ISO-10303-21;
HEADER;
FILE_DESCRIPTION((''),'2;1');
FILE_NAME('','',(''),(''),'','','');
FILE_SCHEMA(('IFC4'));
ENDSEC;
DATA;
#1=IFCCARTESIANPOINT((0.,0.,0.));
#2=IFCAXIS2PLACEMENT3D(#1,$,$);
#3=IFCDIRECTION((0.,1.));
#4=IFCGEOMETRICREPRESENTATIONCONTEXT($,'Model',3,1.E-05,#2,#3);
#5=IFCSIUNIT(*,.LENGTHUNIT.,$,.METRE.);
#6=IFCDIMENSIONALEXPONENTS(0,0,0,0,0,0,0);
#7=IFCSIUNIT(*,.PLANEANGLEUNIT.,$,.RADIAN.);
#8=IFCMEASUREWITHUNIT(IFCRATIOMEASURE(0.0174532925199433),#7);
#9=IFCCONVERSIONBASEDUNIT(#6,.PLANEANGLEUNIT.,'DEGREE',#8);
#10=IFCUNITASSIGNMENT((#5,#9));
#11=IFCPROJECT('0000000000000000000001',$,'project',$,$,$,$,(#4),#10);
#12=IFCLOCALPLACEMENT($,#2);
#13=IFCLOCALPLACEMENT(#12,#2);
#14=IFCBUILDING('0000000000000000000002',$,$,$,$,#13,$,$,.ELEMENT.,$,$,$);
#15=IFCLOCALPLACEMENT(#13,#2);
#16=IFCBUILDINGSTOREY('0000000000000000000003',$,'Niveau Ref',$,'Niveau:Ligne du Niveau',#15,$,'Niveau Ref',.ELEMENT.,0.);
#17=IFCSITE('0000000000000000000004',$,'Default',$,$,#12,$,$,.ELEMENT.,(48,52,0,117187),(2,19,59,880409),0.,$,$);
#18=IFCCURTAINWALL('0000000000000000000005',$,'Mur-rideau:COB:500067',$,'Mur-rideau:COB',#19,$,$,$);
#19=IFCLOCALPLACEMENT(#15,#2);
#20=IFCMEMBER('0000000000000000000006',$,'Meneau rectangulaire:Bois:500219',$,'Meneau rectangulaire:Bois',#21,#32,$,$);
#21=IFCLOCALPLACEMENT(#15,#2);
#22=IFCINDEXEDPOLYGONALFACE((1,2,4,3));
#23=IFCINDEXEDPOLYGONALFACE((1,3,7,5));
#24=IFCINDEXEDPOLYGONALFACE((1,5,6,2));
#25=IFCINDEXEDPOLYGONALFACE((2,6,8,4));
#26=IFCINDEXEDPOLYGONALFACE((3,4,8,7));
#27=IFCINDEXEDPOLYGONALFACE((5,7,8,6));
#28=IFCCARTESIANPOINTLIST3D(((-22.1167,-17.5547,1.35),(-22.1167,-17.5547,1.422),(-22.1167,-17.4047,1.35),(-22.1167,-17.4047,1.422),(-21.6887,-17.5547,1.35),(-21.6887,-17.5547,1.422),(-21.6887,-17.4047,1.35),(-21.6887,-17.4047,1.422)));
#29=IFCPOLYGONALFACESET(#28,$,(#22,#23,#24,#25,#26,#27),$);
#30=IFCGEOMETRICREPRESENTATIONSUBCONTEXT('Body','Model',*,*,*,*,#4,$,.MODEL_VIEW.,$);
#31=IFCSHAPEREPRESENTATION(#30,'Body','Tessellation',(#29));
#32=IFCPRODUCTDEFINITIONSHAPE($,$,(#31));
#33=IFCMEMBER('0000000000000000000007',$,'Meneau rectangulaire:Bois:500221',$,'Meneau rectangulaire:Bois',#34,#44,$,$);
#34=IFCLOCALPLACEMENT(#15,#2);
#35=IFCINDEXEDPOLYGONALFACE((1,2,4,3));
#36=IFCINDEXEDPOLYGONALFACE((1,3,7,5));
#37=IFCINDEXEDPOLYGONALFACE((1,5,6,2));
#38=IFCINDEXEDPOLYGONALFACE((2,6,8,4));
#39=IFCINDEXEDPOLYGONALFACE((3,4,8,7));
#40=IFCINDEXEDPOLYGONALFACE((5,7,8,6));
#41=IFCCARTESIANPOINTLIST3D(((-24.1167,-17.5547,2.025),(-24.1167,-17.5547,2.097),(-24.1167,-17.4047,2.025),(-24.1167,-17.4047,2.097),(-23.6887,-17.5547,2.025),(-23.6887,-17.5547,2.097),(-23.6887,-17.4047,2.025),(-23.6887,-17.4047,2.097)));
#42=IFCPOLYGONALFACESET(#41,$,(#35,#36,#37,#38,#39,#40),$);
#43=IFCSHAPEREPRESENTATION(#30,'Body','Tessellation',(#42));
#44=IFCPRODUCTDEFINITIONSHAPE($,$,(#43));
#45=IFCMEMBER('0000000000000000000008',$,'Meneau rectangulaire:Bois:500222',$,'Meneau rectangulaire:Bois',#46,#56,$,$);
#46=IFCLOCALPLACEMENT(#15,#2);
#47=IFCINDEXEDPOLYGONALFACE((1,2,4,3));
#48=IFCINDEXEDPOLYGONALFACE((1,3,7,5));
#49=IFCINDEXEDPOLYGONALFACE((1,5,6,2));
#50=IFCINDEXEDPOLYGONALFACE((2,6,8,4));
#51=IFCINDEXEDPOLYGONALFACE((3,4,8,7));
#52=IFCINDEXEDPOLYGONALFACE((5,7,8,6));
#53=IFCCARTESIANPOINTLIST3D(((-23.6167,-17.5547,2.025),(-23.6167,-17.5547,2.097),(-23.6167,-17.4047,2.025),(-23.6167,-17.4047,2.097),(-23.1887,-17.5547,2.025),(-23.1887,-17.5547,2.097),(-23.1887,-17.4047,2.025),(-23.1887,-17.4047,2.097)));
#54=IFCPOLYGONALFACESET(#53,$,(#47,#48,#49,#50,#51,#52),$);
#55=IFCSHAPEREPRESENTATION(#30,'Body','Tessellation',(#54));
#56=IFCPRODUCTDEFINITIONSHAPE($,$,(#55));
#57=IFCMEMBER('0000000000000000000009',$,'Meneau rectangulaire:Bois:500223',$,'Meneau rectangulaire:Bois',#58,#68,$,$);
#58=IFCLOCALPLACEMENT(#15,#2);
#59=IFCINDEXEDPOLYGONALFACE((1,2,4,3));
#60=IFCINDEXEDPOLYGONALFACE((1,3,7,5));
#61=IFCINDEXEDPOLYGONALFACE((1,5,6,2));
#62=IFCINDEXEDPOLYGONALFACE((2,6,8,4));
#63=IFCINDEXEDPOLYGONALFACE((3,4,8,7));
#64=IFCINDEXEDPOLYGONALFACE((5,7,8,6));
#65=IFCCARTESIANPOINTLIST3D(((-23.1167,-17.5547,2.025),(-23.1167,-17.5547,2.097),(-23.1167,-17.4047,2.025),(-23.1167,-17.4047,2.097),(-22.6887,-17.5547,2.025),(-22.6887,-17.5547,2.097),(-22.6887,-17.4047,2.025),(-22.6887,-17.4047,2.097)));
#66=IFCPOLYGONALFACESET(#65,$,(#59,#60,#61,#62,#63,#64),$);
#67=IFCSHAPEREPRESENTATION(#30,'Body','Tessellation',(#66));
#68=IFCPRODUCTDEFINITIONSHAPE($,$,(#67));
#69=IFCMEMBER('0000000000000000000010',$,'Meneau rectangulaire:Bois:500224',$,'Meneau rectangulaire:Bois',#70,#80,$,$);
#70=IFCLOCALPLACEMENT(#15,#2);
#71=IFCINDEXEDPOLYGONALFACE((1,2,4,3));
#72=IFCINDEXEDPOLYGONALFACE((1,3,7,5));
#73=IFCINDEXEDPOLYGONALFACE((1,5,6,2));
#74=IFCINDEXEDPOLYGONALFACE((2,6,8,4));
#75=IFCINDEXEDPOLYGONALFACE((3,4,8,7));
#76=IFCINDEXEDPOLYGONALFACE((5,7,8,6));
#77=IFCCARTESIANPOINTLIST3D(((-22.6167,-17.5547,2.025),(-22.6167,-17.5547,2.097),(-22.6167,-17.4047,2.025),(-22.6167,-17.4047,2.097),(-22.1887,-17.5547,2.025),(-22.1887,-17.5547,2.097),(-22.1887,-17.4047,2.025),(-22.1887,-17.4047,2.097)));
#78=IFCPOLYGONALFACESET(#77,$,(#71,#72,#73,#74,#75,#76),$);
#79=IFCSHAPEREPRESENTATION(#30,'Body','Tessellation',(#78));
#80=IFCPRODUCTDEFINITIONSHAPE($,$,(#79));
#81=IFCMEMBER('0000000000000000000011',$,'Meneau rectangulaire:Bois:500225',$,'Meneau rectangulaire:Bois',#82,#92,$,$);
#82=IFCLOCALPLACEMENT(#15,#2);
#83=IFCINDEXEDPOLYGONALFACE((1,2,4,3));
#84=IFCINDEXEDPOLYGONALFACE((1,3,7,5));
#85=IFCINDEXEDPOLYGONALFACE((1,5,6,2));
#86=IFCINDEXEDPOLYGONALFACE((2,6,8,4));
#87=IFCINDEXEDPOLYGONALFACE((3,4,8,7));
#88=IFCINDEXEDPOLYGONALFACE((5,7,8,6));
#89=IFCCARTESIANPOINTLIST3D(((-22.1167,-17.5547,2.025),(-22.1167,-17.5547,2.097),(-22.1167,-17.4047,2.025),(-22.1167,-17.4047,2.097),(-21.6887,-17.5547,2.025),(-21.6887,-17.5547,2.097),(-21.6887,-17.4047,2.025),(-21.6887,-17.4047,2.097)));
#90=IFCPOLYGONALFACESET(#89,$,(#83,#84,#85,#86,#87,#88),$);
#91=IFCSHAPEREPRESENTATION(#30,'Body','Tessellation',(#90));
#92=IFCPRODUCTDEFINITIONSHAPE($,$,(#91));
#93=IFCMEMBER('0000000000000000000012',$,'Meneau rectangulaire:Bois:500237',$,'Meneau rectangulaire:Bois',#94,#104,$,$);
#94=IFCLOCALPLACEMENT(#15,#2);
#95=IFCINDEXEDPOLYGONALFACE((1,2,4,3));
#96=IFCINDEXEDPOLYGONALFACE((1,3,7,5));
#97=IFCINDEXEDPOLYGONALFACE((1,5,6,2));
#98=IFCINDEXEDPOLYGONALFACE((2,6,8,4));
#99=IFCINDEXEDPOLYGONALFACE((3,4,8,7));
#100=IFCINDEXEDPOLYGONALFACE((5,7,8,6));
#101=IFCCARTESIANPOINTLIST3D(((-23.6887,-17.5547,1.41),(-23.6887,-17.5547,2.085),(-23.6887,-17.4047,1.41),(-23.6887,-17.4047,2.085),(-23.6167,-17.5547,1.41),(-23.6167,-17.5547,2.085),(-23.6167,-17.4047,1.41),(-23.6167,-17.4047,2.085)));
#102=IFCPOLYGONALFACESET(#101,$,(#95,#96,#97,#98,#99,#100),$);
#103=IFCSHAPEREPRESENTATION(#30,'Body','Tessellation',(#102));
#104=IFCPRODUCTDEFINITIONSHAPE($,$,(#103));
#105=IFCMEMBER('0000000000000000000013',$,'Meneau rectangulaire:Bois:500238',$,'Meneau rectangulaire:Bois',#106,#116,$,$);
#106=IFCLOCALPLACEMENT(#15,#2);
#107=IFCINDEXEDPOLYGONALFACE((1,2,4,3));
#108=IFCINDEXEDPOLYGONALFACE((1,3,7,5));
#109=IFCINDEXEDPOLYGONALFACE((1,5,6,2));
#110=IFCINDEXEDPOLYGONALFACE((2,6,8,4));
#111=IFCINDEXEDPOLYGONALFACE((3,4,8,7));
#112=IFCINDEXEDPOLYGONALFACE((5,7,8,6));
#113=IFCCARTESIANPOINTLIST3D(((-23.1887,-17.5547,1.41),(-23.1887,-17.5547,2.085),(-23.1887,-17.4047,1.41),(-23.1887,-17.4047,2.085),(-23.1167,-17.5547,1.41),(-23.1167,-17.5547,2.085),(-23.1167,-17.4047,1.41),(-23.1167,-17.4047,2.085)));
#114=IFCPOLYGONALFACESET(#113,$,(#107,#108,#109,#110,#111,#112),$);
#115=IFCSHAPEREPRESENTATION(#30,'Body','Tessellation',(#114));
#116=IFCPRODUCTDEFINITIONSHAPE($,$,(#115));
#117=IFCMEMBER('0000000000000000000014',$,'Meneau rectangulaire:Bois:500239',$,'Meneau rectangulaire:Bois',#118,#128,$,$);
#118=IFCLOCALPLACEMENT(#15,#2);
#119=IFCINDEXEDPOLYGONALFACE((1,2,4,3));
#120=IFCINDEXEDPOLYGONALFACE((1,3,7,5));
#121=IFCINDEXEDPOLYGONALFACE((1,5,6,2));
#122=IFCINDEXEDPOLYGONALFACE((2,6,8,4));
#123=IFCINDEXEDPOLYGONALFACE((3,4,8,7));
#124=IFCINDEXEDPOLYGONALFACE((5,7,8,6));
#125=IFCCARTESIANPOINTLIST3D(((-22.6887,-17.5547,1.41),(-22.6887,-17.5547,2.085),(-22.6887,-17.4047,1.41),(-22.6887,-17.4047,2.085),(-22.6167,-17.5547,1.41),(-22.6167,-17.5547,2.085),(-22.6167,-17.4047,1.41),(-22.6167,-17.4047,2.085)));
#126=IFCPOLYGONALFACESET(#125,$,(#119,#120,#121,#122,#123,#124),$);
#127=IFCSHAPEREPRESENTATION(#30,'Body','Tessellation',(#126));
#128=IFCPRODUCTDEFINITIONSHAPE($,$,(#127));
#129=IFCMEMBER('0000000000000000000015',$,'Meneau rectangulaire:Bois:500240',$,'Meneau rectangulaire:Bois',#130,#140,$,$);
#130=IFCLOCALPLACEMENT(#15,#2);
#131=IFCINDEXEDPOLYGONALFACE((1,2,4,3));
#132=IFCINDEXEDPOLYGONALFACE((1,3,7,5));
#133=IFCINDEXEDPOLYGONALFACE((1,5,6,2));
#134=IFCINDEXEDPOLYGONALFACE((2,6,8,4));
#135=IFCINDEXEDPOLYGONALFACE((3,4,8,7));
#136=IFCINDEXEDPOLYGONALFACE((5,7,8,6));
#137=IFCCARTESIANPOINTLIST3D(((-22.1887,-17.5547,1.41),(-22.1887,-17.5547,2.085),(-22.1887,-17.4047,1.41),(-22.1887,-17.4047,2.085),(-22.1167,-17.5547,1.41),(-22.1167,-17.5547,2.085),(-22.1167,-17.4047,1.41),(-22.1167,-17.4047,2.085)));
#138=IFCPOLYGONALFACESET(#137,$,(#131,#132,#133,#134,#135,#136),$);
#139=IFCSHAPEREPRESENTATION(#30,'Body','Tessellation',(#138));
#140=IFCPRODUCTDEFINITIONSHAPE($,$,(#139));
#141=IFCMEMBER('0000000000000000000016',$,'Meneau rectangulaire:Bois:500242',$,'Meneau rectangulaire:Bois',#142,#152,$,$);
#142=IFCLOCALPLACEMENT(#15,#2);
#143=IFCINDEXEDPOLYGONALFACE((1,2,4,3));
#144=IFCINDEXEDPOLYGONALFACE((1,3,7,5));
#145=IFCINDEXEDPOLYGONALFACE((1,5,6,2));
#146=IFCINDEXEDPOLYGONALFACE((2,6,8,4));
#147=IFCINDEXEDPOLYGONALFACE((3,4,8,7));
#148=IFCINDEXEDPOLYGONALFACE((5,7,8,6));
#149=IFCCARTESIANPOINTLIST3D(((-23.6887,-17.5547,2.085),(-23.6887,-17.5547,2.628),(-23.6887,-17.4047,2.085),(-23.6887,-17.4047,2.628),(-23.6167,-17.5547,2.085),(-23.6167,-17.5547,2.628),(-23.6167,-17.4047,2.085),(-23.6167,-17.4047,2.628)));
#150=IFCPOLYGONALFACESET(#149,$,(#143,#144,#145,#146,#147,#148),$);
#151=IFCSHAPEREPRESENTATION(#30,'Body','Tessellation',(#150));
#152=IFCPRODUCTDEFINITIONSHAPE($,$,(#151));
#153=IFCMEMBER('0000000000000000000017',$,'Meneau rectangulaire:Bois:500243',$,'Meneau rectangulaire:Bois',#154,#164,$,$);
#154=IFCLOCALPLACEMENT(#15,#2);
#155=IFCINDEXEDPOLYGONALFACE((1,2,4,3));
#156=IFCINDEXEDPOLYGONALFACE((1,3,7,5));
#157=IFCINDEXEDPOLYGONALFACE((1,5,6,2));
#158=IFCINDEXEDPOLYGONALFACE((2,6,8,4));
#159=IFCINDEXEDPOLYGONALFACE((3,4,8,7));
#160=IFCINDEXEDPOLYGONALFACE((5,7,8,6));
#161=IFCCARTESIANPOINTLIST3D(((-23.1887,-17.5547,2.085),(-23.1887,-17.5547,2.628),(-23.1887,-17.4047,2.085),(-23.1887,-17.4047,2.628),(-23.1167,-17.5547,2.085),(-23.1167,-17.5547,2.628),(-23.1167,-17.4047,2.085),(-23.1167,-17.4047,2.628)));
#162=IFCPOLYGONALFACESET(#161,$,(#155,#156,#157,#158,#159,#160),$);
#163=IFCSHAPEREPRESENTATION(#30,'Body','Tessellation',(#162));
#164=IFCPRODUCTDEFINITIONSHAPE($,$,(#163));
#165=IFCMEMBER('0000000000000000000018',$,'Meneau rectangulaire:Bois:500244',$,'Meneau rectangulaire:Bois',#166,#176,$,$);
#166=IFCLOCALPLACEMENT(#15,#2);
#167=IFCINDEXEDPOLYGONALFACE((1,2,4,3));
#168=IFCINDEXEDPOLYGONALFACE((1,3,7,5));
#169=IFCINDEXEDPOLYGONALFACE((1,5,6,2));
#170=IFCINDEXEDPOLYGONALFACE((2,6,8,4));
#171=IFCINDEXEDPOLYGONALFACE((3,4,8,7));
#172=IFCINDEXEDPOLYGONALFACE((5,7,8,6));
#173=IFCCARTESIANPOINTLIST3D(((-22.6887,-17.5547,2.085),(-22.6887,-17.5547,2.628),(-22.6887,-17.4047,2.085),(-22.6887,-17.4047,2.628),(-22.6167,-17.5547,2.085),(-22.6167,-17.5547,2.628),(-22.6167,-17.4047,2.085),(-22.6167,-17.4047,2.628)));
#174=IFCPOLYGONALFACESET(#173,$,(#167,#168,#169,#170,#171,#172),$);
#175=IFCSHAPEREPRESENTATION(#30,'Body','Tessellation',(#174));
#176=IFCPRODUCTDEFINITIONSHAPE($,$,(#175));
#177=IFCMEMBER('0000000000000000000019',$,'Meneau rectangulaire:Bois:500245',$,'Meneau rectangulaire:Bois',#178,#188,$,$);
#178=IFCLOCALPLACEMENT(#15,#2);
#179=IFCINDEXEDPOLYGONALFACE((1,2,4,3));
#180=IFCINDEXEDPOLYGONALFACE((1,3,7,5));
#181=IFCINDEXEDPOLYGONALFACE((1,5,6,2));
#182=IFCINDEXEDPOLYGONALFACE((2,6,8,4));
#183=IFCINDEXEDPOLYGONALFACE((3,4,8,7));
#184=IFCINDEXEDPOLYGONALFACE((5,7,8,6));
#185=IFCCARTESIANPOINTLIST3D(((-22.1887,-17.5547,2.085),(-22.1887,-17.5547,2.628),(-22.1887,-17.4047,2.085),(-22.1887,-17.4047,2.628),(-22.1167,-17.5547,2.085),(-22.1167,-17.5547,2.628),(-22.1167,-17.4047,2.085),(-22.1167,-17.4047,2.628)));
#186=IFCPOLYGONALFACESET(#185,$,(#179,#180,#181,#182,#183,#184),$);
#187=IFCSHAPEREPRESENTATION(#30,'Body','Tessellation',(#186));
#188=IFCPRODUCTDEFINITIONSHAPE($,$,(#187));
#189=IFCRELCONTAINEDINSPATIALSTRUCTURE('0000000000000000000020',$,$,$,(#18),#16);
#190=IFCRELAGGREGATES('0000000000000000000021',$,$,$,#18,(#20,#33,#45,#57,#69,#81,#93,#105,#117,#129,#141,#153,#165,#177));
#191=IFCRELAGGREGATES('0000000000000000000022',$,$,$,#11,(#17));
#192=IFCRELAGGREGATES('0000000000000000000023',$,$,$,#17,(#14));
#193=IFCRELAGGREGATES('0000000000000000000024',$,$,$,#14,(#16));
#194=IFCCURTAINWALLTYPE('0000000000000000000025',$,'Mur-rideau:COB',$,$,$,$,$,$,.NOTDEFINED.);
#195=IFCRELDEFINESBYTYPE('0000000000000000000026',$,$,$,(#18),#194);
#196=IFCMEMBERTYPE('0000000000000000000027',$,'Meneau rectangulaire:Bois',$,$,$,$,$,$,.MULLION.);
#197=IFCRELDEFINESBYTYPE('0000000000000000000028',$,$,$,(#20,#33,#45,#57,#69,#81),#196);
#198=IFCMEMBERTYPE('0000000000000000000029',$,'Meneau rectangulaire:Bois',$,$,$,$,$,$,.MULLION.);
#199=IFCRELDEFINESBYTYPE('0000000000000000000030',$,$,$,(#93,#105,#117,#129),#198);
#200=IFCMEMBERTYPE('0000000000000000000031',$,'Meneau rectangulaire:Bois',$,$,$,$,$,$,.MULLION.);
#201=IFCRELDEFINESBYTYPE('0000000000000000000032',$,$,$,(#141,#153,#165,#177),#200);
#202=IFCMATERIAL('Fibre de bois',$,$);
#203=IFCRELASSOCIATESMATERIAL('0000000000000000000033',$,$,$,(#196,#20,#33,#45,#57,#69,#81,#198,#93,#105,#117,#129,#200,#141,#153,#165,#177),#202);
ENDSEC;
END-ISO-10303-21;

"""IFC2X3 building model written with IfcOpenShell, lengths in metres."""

from ifc_helpers import new_model, entity, si_unit, converted_unit, direction, frame, origin, origin_2d_with_axis, place, context, subcontext, project, spatial, rectangle, extrude, source, transform, mapped, material, type_object, type_shapes, element, aggregate, save


model = new_model("IFC2X3")

# Units and contexts
model_context = context("Model", 3, precision=1e-05, world=origin(), true_north=direction((0.0, 1.0)))
body_context = subcontext(model_context, "Body", "Model", "MODEL_VIEW")
ifc_project = project(units=[si_unit("LENGTHUNIT", "METRE"), converted_unit("PLANEANGLEUNIT", "DEGREE", entity("IfcRatioMeasure", 0.0174532925199433), si_unit("PLANEANGLEUNIT", "RADIAN"), dimensions=[0, 0, 0, 0, 0, 0, 0])], contexts=[model_context])

# Site, building, storey
site_placement = place(None, origin())
site = spatial("IfcSite", under=ifc_project, at=site_placement, Name="Default", CompositionType="ELEMENT", RefLatitude=(48, 52, 0, 117187), RefLongitude=(2, 19, 59, 880409), RefElevation=0.0)
building_placement = place(site_placement, origin())
building = spatial("IfcBuilding", under=site, at=building_placement, CompositionType="ELEMENT")
storey_placement = place(building_placement, origin())
storey = spatial("IfcBuildingStorey", under=building, at=storey_placement, Name="Niveau Ref", ObjectType="Niveau:Ligne du Niveau", LongName="Niveau Ref", CompositionType="ELEMENT", Elevation=0.0)

# Curtain wall, members
curtain_wall_type = type_object("IfcCurtainWallType", Name="Mur-rideau:COB", PredefinedType="NOTDEFINED")
curtain_wall_placement = place(storey_placement, origin())
curtain_wall = element("IfcCurtainWall", 1, at=curtain_wall_placement, inside=storey, type_object=curtain_wall_type, Name="Mur-rideau:COB:500067", ObjectType="Mur-rideau:COB")
ifc_material = material(Name="Fibre de bois")
member_type_1 = type_object("IfcMemberType", Name="Meneau rectangulaire:Bois", PredefinedType="MULLION", material=ifc_material)
shared_shape_1 = source(origin(), body_context, "Body", "SweptSolid", [
    extrude(rectangle(XDim=0.15, YDim=0.072, at=origin_2d_with_axis()), frame((-0.024, 0.0, -0.428), z_axis=(0.0, 0.0, 1.0), x_axis=(0.0, -1.0, 0.0)), (0.0, 0.0, 1.0), 0.428),
])
type_shapes(member_type_1, [shared_shape_1])
member_1_placement = place(storey_placement, frame((-21.6887, -17.4797, 1.41), z_axis=(1.0, 0.0, 0.0), x_axis=(0.0, 0.0, 1.0)))
member_1 = element("IfcMember", 2, at=member_1_placement, type_object=member_type_1, material=ifc_material, Name="Meneau rectangulaire:Bois:500219", ObjectType="Meneau rectangulaire:Bois", context=body_context, shape_type="MappedRepresentation", body=[
    mapped(shared_shape_1, transform((0.0, 0.0, 0.0), scale=1.0)),
])
member_2_placement = place(storey_placement, frame((-23.6887, -17.4797, 2.085), z_axis=(1.0, 0.0, 0.0), x_axis=(0.0, 0.0, 1.0)))
member_2 = element("IfcMember", 3, at=member_2_placement, type_object=member_type_1, material=ifc_material, Name="Meneau rectangulaire:Bois:500221", ObjectType="Meneau rectangulaire:Bois", context=body_context, shape_type="MappedRepresentation", body=[
    mapped(shared_shape_1, transform((0.0, 0.0, 0.0), scale=1.0)),
])
member_3_placement = place(storey_placement, frame((-23.1887, -17.4797, 2.085), z_axis=(1.0, 0.0, 0.0), x_axis=(0.0, 0.0, 1.0)))
member_3 = element("IfcMember", 4, at=member_3_placement, type_object=member_type_1, material=ifc_material, Name="Meneau rectangulaire:Bois:500222", ObjectType="Meneau rectangulaire:Bois", context=body_context, shape_type="MappedRepresentation", body=[
    mapped(shared_shape_1, transform((0.0, 0.0, 0.0), scale=1.0)),
])
member_4_placement = place(storey_placement, frame((-22.6887, -17.4797, 2.085), z_axis=(1.0, 0.0, 0.0), x_axis=(0.0, 0.0, 1.0)))
member_4 = element("IfcMember", 5, at=member_4_placement, type_object=member_type_1, material=ifc_material, Name="Meneau rectangulaire:Bois:500223", ObjectType="Meneau rectangulaire:Bois", context=body_context, shape_type="MappedRepresentation", body=[
    mapped(shared_shape_1, transform((0.0, 0.0, 0.0), scale=1.0)),
])
member_5_placement = place(storey_placement, frame((-22.1887, -17.4797, 2.085), z_axis=(1.0, 0.0, 0.0), x_axis=(0.0, 0.0, 1.0)))
member_5 = element("IfcMember", 6, at=member_5_placement, type_object=member_type_1, material=ifc_material, Name="Meneau rectangulaire:Bois:500224", ObjectType="Meneau rectangulaire:Bois", context=body_context, shape_type="MappedRepresentation", body=[
    mapped(shared_shape_1, transform((0.0, 0.0, 0.0), scale=1.0)),
])
member_6_placement = place(storey_placement, frame((-21.6887, -17.4797, 2.085), z_axis=(1.0, 0.0, 0.0), x_axis=(0.0, 0.0, 1.0)))
member_6 = element("IfcMember", 7, at=member_6_placement, type_object=member_type_1, material=ifc_material, Name="Meneau rectangulaire:Bois:500225", ObjectType="Meneau rectangulaire:Bois", context=body_context, shape_type="MappedRepresentation", body=[
    mapped(shared_shape_1, transform((0.0, 0.0, 0.0), scale=1.0)),
])
member_type_2 = type_object("IfcMemberType", Name="Meneau rectangulaire:Bois", PredefinedType="MULLION", material=ifc_material)
shared_shape_2 = source(origin(), body_context, "Body", "SweptSolid", [
    extrude(rectangle(XDim=0.15, YDim=0.072, at=origin_2d_with_axis()), frame((-0.024, 0.0, -0.675), z_axis=(0.0, 0.0, 1.0), x_axis=(0.0, -1.0, 0.0)), (0.0, 0.0, 1.0), 0.675),
])
type_shapes(member_type_2, [shared_shape_2])
member_7_placement = place(storey_placement, frame((-23.6287, -17.4797, 1.41), z_axis=(0.0, 0.0, -1.0), x_axis=(1.0, 0.0, 0.0)))
member_7 = element("IfcMember", 8, at=member_7_placement, type_object=member_type_2, material=ifc_material, Name="Meneau rectangulaire:Bois:500237", ObjectType="Meneau rectangulaire:Bois", context=body_context, shape_type="MappedRepresentation", body=[
    mapped(shared_shape_2, transform((0.0, 0.0, 0.0), scale=1.0)),
])
member_8_placement = place(storey_placement, frame((-23.1287, -17.4797, 1.41), z_axis=(0.0, 0.0, -1.0), x_axis=(1.0, 0.0, 0.0)))
member_8 = element("IfcMember", 9, at=member_8_placement, type_object=member_type_2, material=ifc_material, Name="Meneau rectangulaire:Bois:500238", ObjectType="Meneau rectangulaire:Bois", context=body_context, shape_type="MappedRepresentation", body=[
    mapped(shared_shape_2, transform((0.0, 0.0, 0.0), scale=1.0)),
])
member_9_placement = place(storey_placement, frame((-22.6287, -17.4797, 1.41), z_axis=(0.0, 0.0, -1.0), x_axis=(1.0, 0.0, 0.0)))
member_9 = element("IfcMember", 10, at=member_9_placement, type_object=member_type_2, material=ifc_material, Name="Meneau rectangulaire:Bois:500239", ObjectType="Meneau rectangulaire:Bois", context=body_context, shape_type="MappedRepresentation", body=[
    mapped(shared_shape_2, transform((0.0, 0.0, 0.0), scale=1.0)),
])
member_10_placement = place(storey_placement, frame((-22.1287, -17.4797, 1.41), z_axis=(0.0, 0.0, -1.0), x_axis=(1.0, 0.0, 0.0)))
member_10 = element("IfcMember", 11, at=member_10_placement, type_object=member_type_2, material=ifc_material, Name="Meneau rectangulaire:Bois:500240", ObjectType="Meneau rectangulaire:Bois", context=body_context, shape_type="MappedRepresentation", body=[
    mapped(shared_shape_2, transform((0.0, 0.0, 0.0), scale=1.0)),
])
member_type_3 = type_object("IfcMemberType", Name="Meneau rectangulaire:Bois", PredefinedType="MULLION", material=ifc_material)
shared_shape_3 = source(origin(), body_context, "Body", "SweptSolid", [
    extrude(rectangle(XDim=0.15, YDim=0.072, at=origin_2d_with_axis()), frame((-0.024, 0.0, -0.543), z_axis=(0.0, 0.0, 1.0), x_axis=(0.0, -1.0, 0.0)), (0.0, 0.0, 1.0), 0.543),
])
type_shapes(member_type_3, [shared_shape_3])
member_11_placement = place(storey_placement, frame((-23.6287, -17.4797, 2.085), z_axis=(0.0, 0.0, -1.0), x_axis=(1.0, 0.0, 0.0)))
member_11 = element("IfcMember", 12, at=member_11_placement, type_object=member_type_3, material=ifc_material, Name="Meneau rectangulaire:Bois:500242", ObjectType="Meneau rectangulaire:Bois", context=body_context, shape_type="MappedRepresentation", body=[
    mapped(shared_shape_3, transform((0.0, 0.0, 0.0), scale=1.0)),
])
member_12_placement = place(storey_placement, frame((-23.1287, -17.4797, 2.085), z_axis=(0.0, 0.0, -1.0), x_axis=(1.0, 0.0, 0.0)))
member_12 = element("IfcMember", 13, at=member_12_placement, type_object=member_type_3, material=ifc_material, Name="Meneau rectangulaire:Bois:500243", ObjectType="Meneau rectangulaire:Bois", context=body_context, shape_type="MappedRepresentation", body=[
    mapped(shared_shape_3, transform((0.0, 0.0, 0.0), scale=1.0)),
])
member_13_placement = place(storey_placement, frame((-22.6287, -17.4797, 2.085), z_axis=(0.0, 0.0, -1.0), x_axis=(1.0, 0.0, 0.0)))
member_13 = element("IfcMember", 14, at=member_13_placement, type_object=member_type_3, material=ifc_material, Name="Meneau rectangulaire:Bois:500244", ObjectType="Meneau rectangulaire:Bois", context=body_context, shape_type="MappedRepresentation", body=[
    mapped(shared_shape_3, transform((0.0, 0.0, 0.0), scale=1.0)),
])
member_14_placement = place(storey_placement, frame((-22.1287, -17.4797, 2.085), z_axis=(0.0, 0.0, -1.0), x_axis=(1.0, 0.0, 0.0)))
member_14 = element("IfcMember", 15, at=member_14_placement, type_object=member_type_3, material=ifc_material, Name="Meneau rectangulaire:Bois:500245", ObjectType="Meneau rectangulaire:Bois", context=body_context, shape_type="MappedRepresentation", body=[
    mapped(shared_shape_3, transform((0.0, 0.0, 0.0), scale=1.0)),
])
aggregate(curtain_wall, [member_1, member_2, member_3, member_4, member_5, member_6, member_7, member_8, member_9, member_10, member_11, member_12, member_13, member_14])

save(model, "model.ifc")
